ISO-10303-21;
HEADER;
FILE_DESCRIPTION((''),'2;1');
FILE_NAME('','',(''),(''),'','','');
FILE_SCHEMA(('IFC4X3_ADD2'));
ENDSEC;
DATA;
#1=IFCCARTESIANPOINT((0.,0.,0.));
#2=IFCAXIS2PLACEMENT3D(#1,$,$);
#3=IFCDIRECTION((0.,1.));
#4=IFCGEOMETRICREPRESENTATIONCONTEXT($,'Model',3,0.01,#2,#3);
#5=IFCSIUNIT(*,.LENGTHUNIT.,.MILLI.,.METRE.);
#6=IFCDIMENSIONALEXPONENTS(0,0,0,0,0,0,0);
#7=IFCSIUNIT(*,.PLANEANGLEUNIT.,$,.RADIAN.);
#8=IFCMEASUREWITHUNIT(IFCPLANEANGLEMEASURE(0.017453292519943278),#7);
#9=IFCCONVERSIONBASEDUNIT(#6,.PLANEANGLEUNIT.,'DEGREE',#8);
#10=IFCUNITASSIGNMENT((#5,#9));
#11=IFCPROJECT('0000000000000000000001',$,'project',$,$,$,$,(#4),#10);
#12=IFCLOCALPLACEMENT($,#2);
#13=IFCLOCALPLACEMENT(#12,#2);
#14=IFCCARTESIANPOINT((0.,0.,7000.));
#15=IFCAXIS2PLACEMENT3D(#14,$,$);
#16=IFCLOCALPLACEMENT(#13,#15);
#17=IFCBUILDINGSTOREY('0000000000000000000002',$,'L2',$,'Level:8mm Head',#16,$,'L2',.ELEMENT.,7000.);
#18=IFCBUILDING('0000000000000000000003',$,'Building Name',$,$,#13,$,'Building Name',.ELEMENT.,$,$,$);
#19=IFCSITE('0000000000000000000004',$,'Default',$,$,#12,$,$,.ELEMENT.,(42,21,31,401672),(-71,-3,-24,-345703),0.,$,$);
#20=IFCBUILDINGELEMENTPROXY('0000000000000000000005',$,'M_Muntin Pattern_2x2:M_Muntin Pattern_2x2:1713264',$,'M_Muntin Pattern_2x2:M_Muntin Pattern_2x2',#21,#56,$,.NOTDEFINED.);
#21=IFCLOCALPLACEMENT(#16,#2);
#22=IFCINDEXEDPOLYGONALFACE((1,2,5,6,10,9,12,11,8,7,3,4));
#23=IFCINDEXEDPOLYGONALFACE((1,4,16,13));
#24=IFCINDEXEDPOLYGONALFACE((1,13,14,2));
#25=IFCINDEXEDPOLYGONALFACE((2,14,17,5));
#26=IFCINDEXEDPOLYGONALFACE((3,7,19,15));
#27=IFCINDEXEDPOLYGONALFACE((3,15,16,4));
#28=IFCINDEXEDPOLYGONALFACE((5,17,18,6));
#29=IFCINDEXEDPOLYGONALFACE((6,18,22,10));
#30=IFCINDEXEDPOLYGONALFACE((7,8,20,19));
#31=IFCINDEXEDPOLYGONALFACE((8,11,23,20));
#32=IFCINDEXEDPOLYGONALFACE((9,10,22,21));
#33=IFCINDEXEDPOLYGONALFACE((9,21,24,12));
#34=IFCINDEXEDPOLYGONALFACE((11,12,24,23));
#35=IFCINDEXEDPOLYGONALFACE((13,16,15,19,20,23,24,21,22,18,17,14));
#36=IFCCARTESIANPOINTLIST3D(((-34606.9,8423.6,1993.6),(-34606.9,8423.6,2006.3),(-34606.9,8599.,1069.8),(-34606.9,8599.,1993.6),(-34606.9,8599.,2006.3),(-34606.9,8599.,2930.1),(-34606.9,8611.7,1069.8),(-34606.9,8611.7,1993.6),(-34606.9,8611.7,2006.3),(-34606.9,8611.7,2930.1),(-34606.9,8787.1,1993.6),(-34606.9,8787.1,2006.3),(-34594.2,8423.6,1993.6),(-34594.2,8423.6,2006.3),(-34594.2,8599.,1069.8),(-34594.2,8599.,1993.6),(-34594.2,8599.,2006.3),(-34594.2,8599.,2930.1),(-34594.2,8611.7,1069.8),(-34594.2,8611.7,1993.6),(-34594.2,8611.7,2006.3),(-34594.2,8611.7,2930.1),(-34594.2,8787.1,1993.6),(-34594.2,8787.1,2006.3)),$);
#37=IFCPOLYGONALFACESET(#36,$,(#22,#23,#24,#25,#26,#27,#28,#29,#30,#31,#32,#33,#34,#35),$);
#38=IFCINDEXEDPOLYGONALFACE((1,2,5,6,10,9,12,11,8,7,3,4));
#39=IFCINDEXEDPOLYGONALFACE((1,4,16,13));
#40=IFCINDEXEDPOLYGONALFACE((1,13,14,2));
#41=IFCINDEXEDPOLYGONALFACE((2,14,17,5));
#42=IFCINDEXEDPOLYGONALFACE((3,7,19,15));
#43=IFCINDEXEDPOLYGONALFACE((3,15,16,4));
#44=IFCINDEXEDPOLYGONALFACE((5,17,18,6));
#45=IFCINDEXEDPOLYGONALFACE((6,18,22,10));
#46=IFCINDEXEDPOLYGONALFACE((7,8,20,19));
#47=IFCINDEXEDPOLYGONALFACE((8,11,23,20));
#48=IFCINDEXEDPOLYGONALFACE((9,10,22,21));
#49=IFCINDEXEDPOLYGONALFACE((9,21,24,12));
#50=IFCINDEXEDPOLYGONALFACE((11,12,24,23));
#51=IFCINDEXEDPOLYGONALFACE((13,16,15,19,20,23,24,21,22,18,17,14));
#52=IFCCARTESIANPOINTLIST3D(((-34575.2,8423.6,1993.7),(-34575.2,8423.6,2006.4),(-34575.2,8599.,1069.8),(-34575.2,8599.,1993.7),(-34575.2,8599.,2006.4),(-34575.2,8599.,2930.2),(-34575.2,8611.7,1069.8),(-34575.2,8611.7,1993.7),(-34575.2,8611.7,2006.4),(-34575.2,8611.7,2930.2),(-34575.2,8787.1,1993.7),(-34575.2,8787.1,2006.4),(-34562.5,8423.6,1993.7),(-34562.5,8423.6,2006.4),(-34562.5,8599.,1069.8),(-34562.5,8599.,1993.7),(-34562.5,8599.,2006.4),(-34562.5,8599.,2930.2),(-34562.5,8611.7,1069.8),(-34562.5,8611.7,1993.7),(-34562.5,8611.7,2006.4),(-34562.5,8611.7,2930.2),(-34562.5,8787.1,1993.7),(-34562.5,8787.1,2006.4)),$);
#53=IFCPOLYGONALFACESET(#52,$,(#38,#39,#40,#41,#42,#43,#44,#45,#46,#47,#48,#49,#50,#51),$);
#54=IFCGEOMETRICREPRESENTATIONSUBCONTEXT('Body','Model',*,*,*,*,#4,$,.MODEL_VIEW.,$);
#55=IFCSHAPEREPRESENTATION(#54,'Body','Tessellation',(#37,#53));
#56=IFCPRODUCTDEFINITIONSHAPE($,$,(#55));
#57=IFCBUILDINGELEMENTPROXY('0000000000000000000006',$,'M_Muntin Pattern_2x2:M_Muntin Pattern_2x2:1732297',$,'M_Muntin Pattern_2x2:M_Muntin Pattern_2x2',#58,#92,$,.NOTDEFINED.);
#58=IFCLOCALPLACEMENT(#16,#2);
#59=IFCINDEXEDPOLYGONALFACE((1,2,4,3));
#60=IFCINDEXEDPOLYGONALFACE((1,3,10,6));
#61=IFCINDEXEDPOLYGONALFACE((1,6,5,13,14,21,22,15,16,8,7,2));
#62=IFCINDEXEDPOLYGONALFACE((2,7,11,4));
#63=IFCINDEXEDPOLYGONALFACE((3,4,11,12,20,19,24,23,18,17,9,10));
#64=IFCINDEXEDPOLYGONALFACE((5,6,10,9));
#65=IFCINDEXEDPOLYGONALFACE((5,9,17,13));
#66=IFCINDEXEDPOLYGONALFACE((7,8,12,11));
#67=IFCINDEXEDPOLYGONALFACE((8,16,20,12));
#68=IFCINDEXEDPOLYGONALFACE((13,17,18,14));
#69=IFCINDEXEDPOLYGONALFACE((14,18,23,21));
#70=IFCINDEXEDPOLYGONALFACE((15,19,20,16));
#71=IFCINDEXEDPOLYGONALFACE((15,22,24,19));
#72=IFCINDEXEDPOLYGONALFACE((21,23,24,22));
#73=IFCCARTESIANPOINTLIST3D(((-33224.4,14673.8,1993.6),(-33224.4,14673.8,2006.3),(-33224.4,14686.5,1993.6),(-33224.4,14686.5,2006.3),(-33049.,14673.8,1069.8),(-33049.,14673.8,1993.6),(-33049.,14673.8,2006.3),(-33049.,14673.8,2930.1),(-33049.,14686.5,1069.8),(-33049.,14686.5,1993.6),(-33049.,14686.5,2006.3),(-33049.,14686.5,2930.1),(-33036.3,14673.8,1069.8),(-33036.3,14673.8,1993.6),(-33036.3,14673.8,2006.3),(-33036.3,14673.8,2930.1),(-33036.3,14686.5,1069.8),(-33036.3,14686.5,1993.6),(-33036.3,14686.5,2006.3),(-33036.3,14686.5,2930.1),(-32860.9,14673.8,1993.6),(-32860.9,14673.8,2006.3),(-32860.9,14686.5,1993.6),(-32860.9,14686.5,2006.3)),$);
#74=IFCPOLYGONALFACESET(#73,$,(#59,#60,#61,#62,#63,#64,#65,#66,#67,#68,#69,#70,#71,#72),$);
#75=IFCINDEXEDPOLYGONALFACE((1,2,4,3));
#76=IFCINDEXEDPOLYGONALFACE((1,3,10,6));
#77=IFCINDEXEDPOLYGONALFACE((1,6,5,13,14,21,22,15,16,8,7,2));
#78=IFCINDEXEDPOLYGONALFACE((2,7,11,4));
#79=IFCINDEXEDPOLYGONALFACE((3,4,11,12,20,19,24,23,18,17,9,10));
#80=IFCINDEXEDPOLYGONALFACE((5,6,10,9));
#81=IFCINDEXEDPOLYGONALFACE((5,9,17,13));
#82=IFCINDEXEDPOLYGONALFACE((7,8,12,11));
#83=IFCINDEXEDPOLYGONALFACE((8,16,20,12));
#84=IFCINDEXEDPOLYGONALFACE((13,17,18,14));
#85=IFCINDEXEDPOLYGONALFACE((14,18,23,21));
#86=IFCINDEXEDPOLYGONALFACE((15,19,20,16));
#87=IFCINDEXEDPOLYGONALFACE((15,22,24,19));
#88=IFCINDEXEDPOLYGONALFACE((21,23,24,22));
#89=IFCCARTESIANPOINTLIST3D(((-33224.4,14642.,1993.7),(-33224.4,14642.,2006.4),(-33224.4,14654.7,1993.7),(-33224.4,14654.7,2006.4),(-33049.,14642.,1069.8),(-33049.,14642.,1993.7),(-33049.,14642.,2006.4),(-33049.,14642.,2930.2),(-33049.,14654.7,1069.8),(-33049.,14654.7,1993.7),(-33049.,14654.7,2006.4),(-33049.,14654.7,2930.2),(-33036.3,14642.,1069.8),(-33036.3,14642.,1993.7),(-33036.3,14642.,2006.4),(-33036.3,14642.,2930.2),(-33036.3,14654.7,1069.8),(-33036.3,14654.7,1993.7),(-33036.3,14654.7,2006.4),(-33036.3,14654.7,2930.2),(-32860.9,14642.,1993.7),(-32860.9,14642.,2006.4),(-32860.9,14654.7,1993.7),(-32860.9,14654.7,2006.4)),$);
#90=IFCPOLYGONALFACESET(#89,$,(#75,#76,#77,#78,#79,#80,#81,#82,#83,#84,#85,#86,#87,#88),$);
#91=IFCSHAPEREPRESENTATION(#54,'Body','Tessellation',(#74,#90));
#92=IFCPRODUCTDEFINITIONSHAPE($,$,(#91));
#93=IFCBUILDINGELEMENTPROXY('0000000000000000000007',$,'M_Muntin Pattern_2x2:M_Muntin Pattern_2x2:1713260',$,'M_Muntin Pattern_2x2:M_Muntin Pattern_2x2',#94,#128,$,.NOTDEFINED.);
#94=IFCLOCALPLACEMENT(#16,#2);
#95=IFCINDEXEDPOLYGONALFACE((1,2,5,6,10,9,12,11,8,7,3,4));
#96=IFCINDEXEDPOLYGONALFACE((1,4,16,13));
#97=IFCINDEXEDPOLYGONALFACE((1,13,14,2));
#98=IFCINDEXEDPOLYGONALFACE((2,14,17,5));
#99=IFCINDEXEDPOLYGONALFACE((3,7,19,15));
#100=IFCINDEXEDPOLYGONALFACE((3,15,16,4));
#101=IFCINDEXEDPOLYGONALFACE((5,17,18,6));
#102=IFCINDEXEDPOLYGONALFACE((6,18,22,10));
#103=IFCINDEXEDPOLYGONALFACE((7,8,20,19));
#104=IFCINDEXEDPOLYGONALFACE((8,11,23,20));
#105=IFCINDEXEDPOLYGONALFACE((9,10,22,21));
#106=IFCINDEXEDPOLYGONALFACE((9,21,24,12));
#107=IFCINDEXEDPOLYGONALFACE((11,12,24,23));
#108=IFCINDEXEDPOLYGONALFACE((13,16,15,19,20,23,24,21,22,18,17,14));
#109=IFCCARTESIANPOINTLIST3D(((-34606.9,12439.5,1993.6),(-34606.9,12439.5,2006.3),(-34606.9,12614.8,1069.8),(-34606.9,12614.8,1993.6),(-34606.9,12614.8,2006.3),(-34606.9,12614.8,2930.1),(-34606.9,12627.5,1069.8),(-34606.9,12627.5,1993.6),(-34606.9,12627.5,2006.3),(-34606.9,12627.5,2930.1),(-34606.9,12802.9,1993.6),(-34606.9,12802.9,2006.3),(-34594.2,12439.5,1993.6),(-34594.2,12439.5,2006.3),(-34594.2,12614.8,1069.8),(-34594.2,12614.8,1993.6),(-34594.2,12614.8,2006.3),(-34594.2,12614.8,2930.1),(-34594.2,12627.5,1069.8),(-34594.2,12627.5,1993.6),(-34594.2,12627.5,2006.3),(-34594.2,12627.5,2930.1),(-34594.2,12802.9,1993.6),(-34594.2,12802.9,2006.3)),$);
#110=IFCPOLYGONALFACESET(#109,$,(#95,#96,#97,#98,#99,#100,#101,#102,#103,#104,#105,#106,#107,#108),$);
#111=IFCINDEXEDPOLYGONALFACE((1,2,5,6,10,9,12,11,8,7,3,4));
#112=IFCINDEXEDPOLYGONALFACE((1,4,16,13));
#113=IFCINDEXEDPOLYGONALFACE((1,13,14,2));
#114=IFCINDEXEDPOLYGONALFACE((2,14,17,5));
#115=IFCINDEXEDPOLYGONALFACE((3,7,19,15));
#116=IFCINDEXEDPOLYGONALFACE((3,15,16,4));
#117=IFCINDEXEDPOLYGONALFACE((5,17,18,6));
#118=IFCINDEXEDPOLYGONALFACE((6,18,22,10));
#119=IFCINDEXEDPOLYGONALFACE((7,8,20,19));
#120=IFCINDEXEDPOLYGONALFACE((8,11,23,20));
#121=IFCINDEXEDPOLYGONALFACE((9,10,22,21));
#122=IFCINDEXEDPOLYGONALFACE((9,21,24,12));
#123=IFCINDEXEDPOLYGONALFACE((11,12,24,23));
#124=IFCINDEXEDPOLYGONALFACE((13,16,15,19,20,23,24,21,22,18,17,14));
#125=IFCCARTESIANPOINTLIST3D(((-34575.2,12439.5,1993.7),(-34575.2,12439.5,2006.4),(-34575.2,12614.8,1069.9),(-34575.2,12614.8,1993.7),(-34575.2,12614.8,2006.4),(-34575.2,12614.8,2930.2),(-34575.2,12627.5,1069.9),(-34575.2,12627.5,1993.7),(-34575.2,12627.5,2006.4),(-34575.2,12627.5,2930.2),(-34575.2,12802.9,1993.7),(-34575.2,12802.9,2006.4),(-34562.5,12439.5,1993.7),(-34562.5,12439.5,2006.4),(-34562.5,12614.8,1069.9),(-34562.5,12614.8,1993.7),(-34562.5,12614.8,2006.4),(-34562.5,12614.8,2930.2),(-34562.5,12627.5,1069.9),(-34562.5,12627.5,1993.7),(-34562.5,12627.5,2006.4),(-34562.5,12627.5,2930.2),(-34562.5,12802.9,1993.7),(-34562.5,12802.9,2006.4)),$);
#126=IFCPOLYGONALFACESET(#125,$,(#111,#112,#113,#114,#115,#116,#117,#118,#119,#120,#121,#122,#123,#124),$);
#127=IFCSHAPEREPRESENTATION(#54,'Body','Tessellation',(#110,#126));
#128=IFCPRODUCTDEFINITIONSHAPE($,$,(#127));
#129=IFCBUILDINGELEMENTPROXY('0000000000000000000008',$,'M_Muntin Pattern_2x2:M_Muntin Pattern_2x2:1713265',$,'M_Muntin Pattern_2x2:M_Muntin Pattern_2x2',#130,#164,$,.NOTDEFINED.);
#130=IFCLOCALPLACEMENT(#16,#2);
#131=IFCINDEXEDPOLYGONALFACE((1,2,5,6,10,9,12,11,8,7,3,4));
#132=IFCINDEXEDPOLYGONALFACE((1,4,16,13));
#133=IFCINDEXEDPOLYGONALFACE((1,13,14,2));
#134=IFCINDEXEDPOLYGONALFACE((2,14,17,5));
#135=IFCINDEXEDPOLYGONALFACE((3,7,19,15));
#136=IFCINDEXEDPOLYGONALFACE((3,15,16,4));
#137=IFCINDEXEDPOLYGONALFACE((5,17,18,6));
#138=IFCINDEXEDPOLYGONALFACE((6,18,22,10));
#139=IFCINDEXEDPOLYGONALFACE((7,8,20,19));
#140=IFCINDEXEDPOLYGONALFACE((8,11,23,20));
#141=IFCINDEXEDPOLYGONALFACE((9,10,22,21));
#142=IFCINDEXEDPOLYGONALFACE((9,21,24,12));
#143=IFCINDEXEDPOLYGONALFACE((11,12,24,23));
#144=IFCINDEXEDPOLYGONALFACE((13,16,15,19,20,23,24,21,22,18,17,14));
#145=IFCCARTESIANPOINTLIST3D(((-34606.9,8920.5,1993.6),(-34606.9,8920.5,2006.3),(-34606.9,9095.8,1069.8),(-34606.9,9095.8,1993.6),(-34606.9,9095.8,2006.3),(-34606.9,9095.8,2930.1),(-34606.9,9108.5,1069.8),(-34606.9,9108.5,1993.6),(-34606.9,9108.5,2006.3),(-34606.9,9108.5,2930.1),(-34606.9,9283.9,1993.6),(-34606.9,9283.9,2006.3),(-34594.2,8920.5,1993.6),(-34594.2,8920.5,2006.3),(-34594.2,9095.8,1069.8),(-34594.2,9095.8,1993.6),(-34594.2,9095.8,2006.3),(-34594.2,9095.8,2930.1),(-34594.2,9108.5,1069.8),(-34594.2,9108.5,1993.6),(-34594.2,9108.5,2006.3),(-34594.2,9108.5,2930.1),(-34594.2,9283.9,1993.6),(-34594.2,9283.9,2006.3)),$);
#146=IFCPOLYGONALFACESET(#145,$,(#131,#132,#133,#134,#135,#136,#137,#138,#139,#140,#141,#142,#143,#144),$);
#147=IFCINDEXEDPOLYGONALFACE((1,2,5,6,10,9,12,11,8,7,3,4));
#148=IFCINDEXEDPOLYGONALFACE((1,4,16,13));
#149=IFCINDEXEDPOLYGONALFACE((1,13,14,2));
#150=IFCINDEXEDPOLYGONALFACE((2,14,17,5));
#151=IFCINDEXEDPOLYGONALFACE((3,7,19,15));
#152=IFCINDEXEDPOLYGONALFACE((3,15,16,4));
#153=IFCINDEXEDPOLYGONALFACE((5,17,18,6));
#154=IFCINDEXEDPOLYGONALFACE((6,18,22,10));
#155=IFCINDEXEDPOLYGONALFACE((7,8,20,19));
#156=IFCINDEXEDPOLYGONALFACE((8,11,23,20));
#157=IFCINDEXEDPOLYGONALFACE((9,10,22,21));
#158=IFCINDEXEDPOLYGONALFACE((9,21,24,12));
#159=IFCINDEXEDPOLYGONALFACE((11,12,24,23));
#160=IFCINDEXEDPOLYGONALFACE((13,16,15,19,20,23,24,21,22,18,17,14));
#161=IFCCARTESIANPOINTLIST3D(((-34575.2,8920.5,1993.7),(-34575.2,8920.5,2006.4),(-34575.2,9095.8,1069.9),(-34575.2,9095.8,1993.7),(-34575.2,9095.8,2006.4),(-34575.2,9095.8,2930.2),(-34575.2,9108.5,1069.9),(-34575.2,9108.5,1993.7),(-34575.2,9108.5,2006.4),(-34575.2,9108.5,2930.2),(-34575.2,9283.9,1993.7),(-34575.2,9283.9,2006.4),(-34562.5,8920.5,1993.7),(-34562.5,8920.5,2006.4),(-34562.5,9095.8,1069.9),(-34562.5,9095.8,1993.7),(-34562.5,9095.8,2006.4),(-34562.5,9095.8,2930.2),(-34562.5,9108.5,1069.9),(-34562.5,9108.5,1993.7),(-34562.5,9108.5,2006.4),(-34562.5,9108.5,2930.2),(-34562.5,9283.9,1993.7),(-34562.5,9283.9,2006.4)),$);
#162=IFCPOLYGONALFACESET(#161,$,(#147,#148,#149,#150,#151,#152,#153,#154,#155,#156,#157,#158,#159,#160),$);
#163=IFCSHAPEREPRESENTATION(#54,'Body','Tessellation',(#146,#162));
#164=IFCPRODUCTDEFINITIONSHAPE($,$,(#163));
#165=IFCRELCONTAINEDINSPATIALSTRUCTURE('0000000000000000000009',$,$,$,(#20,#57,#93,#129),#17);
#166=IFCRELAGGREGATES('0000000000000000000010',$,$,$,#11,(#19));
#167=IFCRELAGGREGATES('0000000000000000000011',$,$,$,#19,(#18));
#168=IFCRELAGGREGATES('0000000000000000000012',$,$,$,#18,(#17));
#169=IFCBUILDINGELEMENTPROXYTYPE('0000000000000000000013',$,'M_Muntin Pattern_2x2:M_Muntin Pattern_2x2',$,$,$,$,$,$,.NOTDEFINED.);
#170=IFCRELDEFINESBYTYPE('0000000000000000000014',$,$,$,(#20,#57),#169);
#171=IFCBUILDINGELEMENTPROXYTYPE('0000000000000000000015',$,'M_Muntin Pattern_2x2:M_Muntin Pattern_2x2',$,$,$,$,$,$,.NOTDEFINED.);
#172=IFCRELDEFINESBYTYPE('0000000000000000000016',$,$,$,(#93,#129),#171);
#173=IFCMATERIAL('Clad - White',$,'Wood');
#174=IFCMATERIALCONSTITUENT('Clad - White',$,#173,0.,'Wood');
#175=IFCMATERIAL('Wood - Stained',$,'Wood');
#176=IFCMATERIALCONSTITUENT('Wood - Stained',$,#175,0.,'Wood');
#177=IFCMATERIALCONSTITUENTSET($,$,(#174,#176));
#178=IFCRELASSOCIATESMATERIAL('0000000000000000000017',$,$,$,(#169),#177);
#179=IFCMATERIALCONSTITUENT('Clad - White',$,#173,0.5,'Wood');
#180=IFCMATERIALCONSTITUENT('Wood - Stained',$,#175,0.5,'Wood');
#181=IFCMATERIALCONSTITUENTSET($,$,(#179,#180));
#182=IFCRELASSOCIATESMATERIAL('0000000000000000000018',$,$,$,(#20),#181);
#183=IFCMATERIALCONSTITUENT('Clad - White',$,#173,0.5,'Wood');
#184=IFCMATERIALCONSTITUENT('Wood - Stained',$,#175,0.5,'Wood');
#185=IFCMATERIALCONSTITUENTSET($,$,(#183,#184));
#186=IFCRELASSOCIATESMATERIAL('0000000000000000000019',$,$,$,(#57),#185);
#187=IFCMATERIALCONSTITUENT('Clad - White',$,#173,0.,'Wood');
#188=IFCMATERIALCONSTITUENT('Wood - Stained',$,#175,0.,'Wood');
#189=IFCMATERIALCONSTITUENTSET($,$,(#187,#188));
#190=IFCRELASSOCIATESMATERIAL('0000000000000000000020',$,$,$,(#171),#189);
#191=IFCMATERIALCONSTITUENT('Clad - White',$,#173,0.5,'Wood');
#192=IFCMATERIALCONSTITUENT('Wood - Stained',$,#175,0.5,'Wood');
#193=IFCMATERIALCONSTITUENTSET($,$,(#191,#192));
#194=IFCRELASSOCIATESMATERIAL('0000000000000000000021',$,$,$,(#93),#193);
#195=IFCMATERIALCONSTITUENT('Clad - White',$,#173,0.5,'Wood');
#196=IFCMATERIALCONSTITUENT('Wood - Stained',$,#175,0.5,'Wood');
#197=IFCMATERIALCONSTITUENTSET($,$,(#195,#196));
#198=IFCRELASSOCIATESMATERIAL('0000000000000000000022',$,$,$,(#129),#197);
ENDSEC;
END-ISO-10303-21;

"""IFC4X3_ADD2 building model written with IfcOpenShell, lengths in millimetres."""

from ifc_helpers import new_model, entity, si_unit, converted_unit, direction, frame, origin, place, context, subcontext, project, spatial, polyline, outline, extrude, source, transform, mapped, material, constituent, constituent_set, type_object, type_shapes, element, save


model = new_model("IFC4X3_ADD2")

# Units and contexts
model_context = context("Model", 3, precision=0.01, world=origin(), true_north=direction((0.0, 1.0)))
body_context = subcontext(model_context, "Body", "Model", "MODEL_VIEW")
ifc_project = project(units=[si_unit("LENGTHUNIT", "METRE", prefix="MILLI"), converted_unit("PLANEANGLEUNIT", "DEGREE", entity("IfcPlaneAngleMeasure", 0.017453292519943278), si_unit("PLANEANGLEUNIT", "RADIAN"), dimensions=[0, 0, 0, 0, 0, 0, 0])], contexts=[model_context])

# Site, building, storey
site_placement = place(None, origin())
site = spatial("IfcSite", under=ifc_project, at=site_placement, Name="Default", CompositionType="ELEMENT", RefLatitude=(42, 21, 31, 401672), RefLongitude=(-71, -3, -24, -345703), RefElevation=0.0)
building_placement = place(site_placement, origin())
building = spatial("IfcBuilding", under=site, at=building_placement, Name="Building Name", LongName="Building Name", CompositionType="ELEMENT")
storey_placement = place(building_placement, frame((0.0, 0.0, 7000.0)))
storey = spatial("IfcBuildingStorey", under=building, at=storey_placement, Name="L2", ObjectType="Level:8mm Head", LongName="L2", CompositionType="ELEMENT", Elevation=7000.0)

# Building element proxies
ifc_material_1 = material(Name="Clad - White", Category="Wood")
ifc_material_2 = material(Name="Wood - Stained", Category="Wood")
ifc_constituent_1 = constituent(ifc_material_1, Name="Clad - White", Category="Wood", fraction=0.0)
ifc_constituent_2 = constituent(ifc_material_2, Name="Wood - Stained", Category="Wood", fraction=0.0)
ifc_constituent_set_1 = constituent_set(constituents=[ifc_constituent_1, ifc_constituent_2])
building_element_proxy_type_1 = type_object("IfcBuildingElementProxyType", Name="M_Muntin Pattern_2x2:M_Muntin Pattern_2x2", PredefinedType="NOTDEFINED", material=ifc_constituent_set_1)
shared_shape_1 = source(origin(), body_context, "Body", "SweptSolid", [
    extrude(outline(polyline([(6.4, -6.4), (930.1, -6.4), (930.1, 6.3), (6.4, 6.3), (6.4, 181.7), (-6.3, 181.7), (-6.3, 6.3), (-930.2, 6.3), (-930.2, -6.4), (-6.3, -6.4), (-6.3, -181.7), (6.4, -181.7), (6.4, -6.4)])), frame((0.0, 9.5, 930.1), z_axis=(0.0, 1.0, 0.0), x_axis=(0.0, 0.0, 1.0)), (0.0, 0.0, 1.0), 12.7),
    extrude(outline(polyline([(6.4, -6.4), (930.2, -6.4), (930.2, 6.3), (6.4, 6.3), (6.4, 181.7), (-6.3, 181.7), (-6.3, 6.3), (-930.2, 6.3), (-930.2, -6.4), (-6.3, -6.4), (-6.3, -181.7), (6.4, -181.7), (6.4, -6.4)])), frame((0.0, -22.2, 930.2), z_axis=(0.0, 1.0, 0.0), x_axis=(0.0, 0.0, 1.0)), (0.0, 0.0, 1.0), 12.7),
])
type_shapes(building_element_proxy_type_1, [shared_shape_1])
ifc_constituent_3 = constituent(ifc_material_1, Name="Clad - White", Category="Wood", fraction=0.5)
ifc_constituent_4 = constituent(ifc_material_2, Name="Wood - Stained", Category="Wood", fraction=0.5)
ifc_constituent_set_2 = constituent_set(constituents=[ifc_constituent_3, ifc_constituent_4])
proxy_1_placement = place(storey_placement, frame((-34584.7, 8605.4, 1069.8), z_axis=(0.0, 0.0, 1.0), x_axis=(0.0, 1.0, 0.0)))
element("IfcBuildingElementProxy", 1, at=proxy_1_placement, inside=storey, type_object=building_element_proxy_type_1, material=ifc_constituent_set_2, Name="M_Muntin Pattern_2x2:M_Muntin Pattern_2x2:1713264", ObjectType="M_Muntin Pattern_2x2:M_Muntin Pattern_2x2", PredefinedType="NOTDEFINED", context=body_context, shape_type="MappedRepresentation", body=[
    mapped(shared_shape_1, transform((0.0, 0.0, 0.0), scale=1.0)),
])
ifc_constituent_5 = constituent(ifc_material_1, Name="Clad - White", Category="Wood", fraction=0.5)
ifc_constituent_6 = constituent(ifc_material_2, Name="Wood - Stained", Category="Wood", fraction=0.5)
ifc_constituent_set_3 = constituent_set(constituents=[ifc_constituent_5, ifc_constituent_6])
proxy_2_placement = place(storey_placement, frame((-33042.6, 14664.3, 1069.8)))
element("IfcBuildingElementProxy", 2, at=proxy_2_placement, inside=storey, type_object=building_element_proxy_type_1, material=ifc_constituent_set_3, Name="M_Muntin Pattern_2x2:M_Muntin Pattern_2x2:1732297", ObjectType="M_Muntin Pattern_2x2:M_Muntin Pattern_2x2", PredefinedType="NOTDEFINED", context=body_context, shape_type="MappedRepresentation", body=[
    mapped(shared_shape_1, transform((0.0, 0.0, 0.0), scale=1.0)),
])
ifc_constituent_7 = constituent(ifc_material_1, Name="Clad - White", Category="Wood", fraction=0.5)
ifc_constituent_8 = constituent(ifc_material_2, Name="Wood - Stained", Category="Wood", fraction=0.5)
ifc_constituent_set_4 = constituent_set(constituents=[ifc_constituent_7, ifc_constituent_8])
ifc_constituent_9 = constituent(ifc_material_1, Name="Clad - White", Category="Wood", fraction=0.0)
ifc_constituent_10 = constituent(ifc_material_2, Name="Wood - Stained", Category="Wood", fraction=0.0)
ifc_constituent_set_5 = constituent_set(constituents=[ifc_constituent_9, ifc_constituent_10])
building_element_proxy_type_2 = type_object("IfcBuildingElementProxyType", Name="M_Muntin Pattern_2x2:M_Muntin Pattern_2x2", PredefinedType="NOTDEFINED", material=ifc_constituent_set_5)
shared_shape_2 = source(origin(), body_context, "Body", "SweptSolid", [
    extrude(outline(polyline([(6.4, -6.4), (930.1, -6.4), (930.1, 6.3), (6.4, 6.3), (6.4, 181.7), (-6.3, 181.7), (-6.3, 6.3), (-930.2, 6.3), (-930.2, -6.4), (-6.3, -6.4), (-6.3, -181.7), (6.4, -181.7), (6.4, -6.4)])), frame((0.0, -22.2, 930.1), z_axis=(0.0, 1.0, 0.0), x_axis=(0.0, 0.0, 1.0)), (0.0, 0.0, 1.0), 12.7),
    extrude(outline(polyline([(6.4, -6.4), (930.2, -6.4), (930.2, 6.3), (6.4, 6.3), (6.4, 181.7), (-6.3, 181.7), (-6.3, 6.3), (-930.2, 6.3), (-930.2, -6.4), (-6.3, -6.4), (-6.3, -181.7), (6.4, -181.7), (6.4, -6.4)])), frame((0.0, 9.5, 930.2), z_axis=(0.0, 1.0, 0.0), x_axis=(0.0, 0.0, 1.0)), (0.0, 0.0, 1.0), 12.7),
])
type_shapes(building_element_proxy_type_2, [shared_shape_2])
proxy_3_placement = place(storey_placement, frame((-34584.7, 12621.2, 1069.9), z_axis=(0.0, 0.0, 1.0), x_axis=(0.0, -1.0, 0.0)))
element("IfcBuildingElementProxy", 3, at=proxy_3_placement, inside=storey, type_object=building_element_proxy_type_2, material=ifc_constituent_set_4, Name="M_Muntin Pattern_2x2:M_Muntin Pattern_2x2:1713260", ObjectType="M_Muntin Pattern_2x2:M_Muntin Pattern_2x2", PredefinedType="NOTDEFINED", context=body_context, shape_type="MappedRepresentation", body=[
    mapped(shared_shape_2, transform((0.0, 0.0, 0.0), scale=1.0)),
])
ifc_constituent_11 = constituent(ifc_material_1, Name="Clad - White", Category="Wood", fraction=0.5)
ifc_constituent_12 = constituent(ifc_material_2, Name="Wood - Stained", Category="Wood", fraction=0.5)
ifc_constituent_set_6 = constituent_set(constituents=[ifc_constituent_11, ifc_constituent_12])
proxy_4_placement = place(storey_placement, frame((-34584.7, 9102.2, 1069.9), z_axis=(0.0, 0.0, 1.0), x_axis=(0.0, -1.0, 0.0)))
element("IfcBuildingElementProxy", 4, at=proxy_4_placement, inside=storey, type_object=building_element_proxy_type_2, material=ifc_constituent_set_6, Name="M_Muntin Pattern_2x2:M_Muntin Pattern_2x2:1713265", ObjectType="M_Muntin Pattern_2x2:M_Muntin Pattern_2x2", PredefinedType="NOTDEFINED", context=body_context, shape_type="MappedRepresentation", body=[
    mapped(shared_shape_2, transform((0.0, 0.0, 0.0), scale=1.0)),
])

save(model, "model.ifc")
